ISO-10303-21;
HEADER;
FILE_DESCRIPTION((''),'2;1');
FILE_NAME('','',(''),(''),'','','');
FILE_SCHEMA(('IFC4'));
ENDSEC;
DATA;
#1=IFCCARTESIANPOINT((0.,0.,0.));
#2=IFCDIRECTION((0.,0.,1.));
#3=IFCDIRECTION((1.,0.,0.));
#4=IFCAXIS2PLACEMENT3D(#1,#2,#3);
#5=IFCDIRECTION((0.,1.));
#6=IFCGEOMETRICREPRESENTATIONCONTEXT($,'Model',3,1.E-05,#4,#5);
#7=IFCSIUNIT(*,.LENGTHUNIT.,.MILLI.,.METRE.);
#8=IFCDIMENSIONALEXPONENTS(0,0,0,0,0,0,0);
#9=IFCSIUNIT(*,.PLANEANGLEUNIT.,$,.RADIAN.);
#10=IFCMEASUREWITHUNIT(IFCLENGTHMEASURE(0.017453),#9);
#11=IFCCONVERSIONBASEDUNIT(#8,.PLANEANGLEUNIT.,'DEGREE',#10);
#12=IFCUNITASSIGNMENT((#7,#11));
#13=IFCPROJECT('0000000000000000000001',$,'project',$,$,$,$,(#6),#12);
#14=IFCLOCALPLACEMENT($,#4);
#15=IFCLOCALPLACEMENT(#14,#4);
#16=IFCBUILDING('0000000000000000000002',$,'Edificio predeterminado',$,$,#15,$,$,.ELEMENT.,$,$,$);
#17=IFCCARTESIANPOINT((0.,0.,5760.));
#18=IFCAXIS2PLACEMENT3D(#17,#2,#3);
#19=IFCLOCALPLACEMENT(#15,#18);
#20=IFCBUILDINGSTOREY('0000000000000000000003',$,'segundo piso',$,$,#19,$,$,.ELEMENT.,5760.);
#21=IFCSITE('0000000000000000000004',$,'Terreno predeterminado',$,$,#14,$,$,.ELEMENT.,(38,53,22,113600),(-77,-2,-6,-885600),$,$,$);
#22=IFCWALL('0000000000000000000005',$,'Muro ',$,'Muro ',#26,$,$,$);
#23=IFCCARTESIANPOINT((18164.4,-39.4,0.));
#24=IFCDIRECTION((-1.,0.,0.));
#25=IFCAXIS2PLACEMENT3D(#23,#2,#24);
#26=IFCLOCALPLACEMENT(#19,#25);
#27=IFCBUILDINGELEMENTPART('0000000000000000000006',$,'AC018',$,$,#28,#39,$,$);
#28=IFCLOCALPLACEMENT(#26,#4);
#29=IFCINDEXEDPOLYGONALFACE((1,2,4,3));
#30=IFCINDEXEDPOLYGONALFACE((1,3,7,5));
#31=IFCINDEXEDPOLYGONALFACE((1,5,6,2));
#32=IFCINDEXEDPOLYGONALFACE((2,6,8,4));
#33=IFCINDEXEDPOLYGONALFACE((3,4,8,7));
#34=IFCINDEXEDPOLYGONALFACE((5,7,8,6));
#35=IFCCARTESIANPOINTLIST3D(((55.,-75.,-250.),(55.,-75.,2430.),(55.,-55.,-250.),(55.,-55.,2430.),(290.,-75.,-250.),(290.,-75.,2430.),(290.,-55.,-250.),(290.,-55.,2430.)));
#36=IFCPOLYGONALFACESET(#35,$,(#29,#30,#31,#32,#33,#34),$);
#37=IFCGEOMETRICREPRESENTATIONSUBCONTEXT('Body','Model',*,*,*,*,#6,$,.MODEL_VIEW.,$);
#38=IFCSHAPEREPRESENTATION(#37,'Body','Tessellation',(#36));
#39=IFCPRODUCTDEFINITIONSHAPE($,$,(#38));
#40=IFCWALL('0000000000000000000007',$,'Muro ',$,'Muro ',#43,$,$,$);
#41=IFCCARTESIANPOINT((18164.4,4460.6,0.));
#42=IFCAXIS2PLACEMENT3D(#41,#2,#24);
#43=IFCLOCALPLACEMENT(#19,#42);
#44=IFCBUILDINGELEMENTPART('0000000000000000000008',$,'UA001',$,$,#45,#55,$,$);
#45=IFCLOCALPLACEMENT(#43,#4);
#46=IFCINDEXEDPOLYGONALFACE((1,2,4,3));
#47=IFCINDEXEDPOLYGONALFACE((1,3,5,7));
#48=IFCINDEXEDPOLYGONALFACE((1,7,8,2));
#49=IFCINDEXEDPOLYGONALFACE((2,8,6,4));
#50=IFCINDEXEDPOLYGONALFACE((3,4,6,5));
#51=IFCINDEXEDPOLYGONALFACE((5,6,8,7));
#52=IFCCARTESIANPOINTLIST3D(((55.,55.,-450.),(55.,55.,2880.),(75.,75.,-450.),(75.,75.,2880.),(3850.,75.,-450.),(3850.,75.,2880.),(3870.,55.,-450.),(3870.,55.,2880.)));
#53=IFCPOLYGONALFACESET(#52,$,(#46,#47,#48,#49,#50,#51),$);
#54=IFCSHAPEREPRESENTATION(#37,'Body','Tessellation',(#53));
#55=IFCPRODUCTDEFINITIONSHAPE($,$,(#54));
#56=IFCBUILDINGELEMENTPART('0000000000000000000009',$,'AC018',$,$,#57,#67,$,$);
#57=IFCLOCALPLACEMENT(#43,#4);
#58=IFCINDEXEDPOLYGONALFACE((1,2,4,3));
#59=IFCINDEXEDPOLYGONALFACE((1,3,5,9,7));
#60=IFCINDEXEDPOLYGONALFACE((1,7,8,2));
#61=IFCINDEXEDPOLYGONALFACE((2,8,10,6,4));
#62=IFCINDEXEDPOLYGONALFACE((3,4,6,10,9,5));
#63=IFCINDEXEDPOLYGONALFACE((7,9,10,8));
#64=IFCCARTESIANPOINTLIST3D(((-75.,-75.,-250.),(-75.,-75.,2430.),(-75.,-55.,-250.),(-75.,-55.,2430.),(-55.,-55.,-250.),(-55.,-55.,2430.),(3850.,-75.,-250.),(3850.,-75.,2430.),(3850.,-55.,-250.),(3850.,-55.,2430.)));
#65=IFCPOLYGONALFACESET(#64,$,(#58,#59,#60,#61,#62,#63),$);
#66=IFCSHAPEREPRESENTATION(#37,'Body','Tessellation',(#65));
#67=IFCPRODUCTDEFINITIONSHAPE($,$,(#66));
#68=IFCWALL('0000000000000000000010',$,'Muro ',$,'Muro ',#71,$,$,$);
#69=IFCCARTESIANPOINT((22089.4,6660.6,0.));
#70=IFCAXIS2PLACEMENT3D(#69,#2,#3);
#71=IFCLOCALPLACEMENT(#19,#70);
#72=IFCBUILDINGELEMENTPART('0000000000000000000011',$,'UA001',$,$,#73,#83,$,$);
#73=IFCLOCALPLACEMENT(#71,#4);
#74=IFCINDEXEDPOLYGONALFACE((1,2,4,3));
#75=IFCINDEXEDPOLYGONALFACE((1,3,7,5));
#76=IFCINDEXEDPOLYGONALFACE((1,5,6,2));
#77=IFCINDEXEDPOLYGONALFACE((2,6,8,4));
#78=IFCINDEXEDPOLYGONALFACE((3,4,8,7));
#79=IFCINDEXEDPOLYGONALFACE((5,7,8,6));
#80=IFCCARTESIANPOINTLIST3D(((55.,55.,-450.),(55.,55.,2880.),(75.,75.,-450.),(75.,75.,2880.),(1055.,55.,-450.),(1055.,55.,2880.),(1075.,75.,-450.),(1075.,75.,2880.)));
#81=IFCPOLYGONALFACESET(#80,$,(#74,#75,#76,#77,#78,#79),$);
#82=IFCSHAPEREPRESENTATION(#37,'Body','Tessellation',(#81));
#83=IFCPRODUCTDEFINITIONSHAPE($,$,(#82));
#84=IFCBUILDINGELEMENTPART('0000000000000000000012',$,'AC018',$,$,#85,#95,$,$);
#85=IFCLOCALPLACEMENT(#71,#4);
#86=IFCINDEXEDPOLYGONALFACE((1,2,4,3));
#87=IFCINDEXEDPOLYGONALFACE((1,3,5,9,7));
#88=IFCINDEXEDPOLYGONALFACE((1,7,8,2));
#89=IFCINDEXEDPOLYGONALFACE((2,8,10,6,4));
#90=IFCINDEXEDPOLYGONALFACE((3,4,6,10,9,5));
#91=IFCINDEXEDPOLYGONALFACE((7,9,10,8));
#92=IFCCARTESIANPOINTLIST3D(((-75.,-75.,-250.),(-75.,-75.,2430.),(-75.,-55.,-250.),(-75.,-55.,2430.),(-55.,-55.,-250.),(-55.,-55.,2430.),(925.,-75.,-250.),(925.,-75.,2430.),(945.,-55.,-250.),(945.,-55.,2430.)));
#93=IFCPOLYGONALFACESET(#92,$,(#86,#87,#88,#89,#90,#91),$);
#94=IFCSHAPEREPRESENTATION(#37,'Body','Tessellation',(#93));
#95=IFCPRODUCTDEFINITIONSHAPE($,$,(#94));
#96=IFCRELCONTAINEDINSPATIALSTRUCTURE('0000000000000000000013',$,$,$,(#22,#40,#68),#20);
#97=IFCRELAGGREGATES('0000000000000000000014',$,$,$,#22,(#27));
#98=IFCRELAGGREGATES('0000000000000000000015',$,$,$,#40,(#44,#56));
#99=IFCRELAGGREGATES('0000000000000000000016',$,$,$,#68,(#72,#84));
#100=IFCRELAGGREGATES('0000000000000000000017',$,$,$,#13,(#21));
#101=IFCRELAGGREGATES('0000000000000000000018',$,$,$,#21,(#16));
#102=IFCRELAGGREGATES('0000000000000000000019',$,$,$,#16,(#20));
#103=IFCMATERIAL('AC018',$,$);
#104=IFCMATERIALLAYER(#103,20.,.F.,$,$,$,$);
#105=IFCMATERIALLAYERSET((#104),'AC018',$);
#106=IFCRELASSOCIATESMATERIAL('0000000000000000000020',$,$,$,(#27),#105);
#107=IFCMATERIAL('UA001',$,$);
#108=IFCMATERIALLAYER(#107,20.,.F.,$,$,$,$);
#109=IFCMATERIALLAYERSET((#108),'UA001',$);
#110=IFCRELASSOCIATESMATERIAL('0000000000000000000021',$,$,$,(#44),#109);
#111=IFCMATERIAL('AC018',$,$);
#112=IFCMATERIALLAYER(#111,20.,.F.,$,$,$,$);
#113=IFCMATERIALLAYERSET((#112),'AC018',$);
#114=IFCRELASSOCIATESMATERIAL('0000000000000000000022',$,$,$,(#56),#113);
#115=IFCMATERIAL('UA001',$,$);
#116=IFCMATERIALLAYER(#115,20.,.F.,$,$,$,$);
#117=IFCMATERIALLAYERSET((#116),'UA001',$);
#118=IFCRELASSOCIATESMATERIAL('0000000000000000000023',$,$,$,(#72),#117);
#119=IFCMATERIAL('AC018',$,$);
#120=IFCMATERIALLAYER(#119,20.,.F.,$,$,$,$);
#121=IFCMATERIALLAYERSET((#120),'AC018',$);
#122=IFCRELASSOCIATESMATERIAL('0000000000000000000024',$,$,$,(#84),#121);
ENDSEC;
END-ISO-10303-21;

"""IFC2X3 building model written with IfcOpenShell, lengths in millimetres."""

from ifc_helpers import new_model, entity, si_unit, converted_unit, direction, frame, origin_with_axes, place, context, subcontext, project, spatial, polyline, outline, extrude, material, layer, layer_set, layer_usage, element, aggregate, save


model = new_model("IFC2X3")

# Units and contexts
model_context = context("Model", 3, precision=1e-05, world=origin_with_axes(), true_north=direction((0.0, 1.0)))
body_context = subcontext(model_context, "Body", "Model", "MODEL_VIEW")
ifc_project = project(units=[si_unit("LENGTHUNIT", "METRE", prefix="MILLI"), converted_unit("PLANEANGLEUNIT", "DEGREE", entity("IfcLengthMeasure", 0.017453), si_unit("PLANEANGLEUNIT", "RADIAN"), dimensions=[0, 0, 0, 0, 0, 0, 0])], contexts=[model_context])

# Site, building, storey
site_placement = place(None, origin_with_axes())
site = spatial("IfcSite", under=ifc_project, at=site_placement, Name="Terreno predeterminado", CompositionType="ELEMENT", RefLatitude=(38, 53, 22, 113600), RefLongitude=(-77, -2, -6, -885600))
building_placement = place(site_placement, origin_with_axes())
building = spatial("IfcBuilding", under=site, at=building_placement, Name="Edificio predeterminado", CompositionType="ELEMENT")
storey_placement = place(building_placement, frame((0.0, 0.0, 5760.0), z_axis=(0.0, 0.0, 1.0), x_axis=(1.0, 0.0, 0.0)))
storey = spatial("IfcBuildingStorey", under=building, at=storey_placement, Name="segundo piso", CompositionType="ELEMENT", Elevation=5760.0)

# Wall, building element part
wall_1_placement = place(storey_placement, frame((18164.4, -39.4, 0.0), z_axis=(0.0, 0.0, 1.0), x_axis=(-1.0, 0.0, 0.0)))
wall_1 = element("IfcWall", 1, at=wall_1_placement, inside=storey, Name="Muro ", ObjectType="Muro ")
ifc_material_1 = material(Name="AC018")
ifc_layer_1 = layer(ifc_material_1, 20.0, ventilated=False)
ifc_layer_set_1 = layer_set([ifc_layer_1], Name="AC018")
ifc_layer_usage_1 = layer_usage(ifc_layer_set_1, "AXIS2", "NEGATIVE", 55.0)
building_element_part_1_placement = place(wall_1_placement, origin_with_axes())
building_element_part_1 = element("IfcBuildingElementPart", 2, at=building_element_part_1_placement, material=ifc_layer_usage_1, Name="AC018", context=body_context, shape_type="SweptSolid", body=[
    extrude(outline(polyline([(290.0, -55.0), (290.0, -75.0), (55.0, -75.0), (55.0, -55.0), (290.0, -55.0)])), frame((0.0, 0.0, -250.0), z_axis=(0.0, 0.0, 1.0), x_axis=(1.0, 0.0, 0.0)), (0.0, 0.0, 1.0), 2680.0),
])
aggregate(wall_1, [building_element_part_1])

# Walls, building element parts
wall_2_placement = place(storey_placement, frame((18164.4, 4460.6, 0.0), z_axis=(0.0, 0.0, 1.0), x_axis=(-1.0, 0.0, 0.0)))
wall_2 = element("IfcWall", 3, at=wall_2_placement, inside=storey, Name="Muro ", ObjectType="Muro ")
ifc_material_2 = material(Name="UA001")
ifc_layer_2 = layer(ifc_material_2, 20.0, ventilated=False)
ifc_layer_set_2 = layer_set([ifc_layer_2], Name="UA001")
ifc_layer_usage_2 = layer_usage(ifc_layer_set_2, "AXIS2", "NEGATIVE", -75.0)
building_element_part_2_placement = place(wall_2_placement, origin_with_axes())
building_element_part_2 = element("IfcBuildingElementPart", 4, at=building_element_part_2_placement, material=ifc_layer_usage_2, Name="UA001", context=body_context, shape_type="SweptSolid", body=[
    extrude(outline(polyline([(3850.0, 75.0), (3870.0, 55.0), (55.0, 55.0), (75.0, 75.0), (3850.0, 75.0)])), frame((0.0, 0.0, -450.0), z_axis=(0.0, 0.0, 1.0), x_axis=(1.0, 0.0, 0.0)), (0.0, 0.0, 1.0), 3330.0),
])
ifc_material_3 = material(Name="AC018")
ifc_layer_3 = layer(ifc_material_3, 20.0, ventilated=False)
ifc_layer_set_3 = layer_set([ifc_layer_3], Name="AC018")
ifc_layer_usage_3 = layer_usage(ifc_layer_set_3, "AXIS2", "NEGATIVE", 55.0)
building_element_part_3_placement = place(wall_2_placement, origin_with_axes())
building_element_part_3 = element("IfcBuildingElementPart", 5, at=building_element_part_3_placement, material=ifc_layer_usage_3, Name="AC018", context=body_context, shape_type="SweptSolid", body=[
    extrude(outline(polyline([(3850.0, -55.0), (3850.0, -75.0), (-75.0, -75.0), (-75.0, -55.0), (-55.0, -55.0), (3850.0, -55.0)])), frame((0.0, 0.0, -250.0), z_axis=(0.0, 0.0, 1.0), x_axis=(1.0, 0.0, 0.0)), (0.0, 0.0, 1.0), 2680.0),
])
aggregate(wall_2, [building_element_part_2, building_element_part_3])
wall_3_placement = place(storey_placement, frame((22089.4, 6660.6, 0.0), z_axis=(0.0, 0.0, 1.0), x_axis=(1.0, 0.0, 0.0)))
wall_3 = element("IfcWall", 6, at=wall_3_placement, inside=storey, Name="Muro ", ObjectType="Muro ")
ifc_material_4 = material(Name="UA001")
ifc_layer_4 = layer(ifc_material_4, 20.0, ventilated=False)
ifc_layer_set_4 = layer_set([ifc_layer_4], Name="UA001")
ifc_layer_usage_4 = layer_usage(ifc_layer_set_4, "AXIS2", "NEGATIVE", -75.0)
building_element_part_4_placement = place(wall_3_placement, origin_with_axes())
building_element_part_4 = element("IfcBuildingElementPart", 7, at=building_element_part_4_placement, material=ifc_layer_usage_4, Name="UA001", context=body_context, shape_type="SweptSolid", body=[
    extrude(outline(polyline([(1075.0, 75.0), (1055.0, 55.0), (55.0, 55.0), (75.0, 75.0), (1075.0, 75.0)])), frame((0.0, 0.0, -450.0), z_axis=(0.0, 0.0, 1.0), x_axis=(1.0, 0.0, 0.0)), (0.0, 0.0, 1.0), 3330.0),
])
ifc_material_5 = material(Name="AC018")
ifc_layer_5 = layer(ifc_material_5, 20.0, ventilated=False)
ifc_layer_set_5 = layer_set([ifc_layer_5], Name="AC018")
ifc_layer_usage_5 = layer_usage(ifc_layer_set_5, "AXIS2", "NEGATIVE", 55.0)
building_element_part_5_placement = place(wall_3_placement, origin_with_axes())
building_element_part_5 = element("IfcBuildingElementPart", 8, at=building_element_part_5_placement, material=ifc_layer_usage_5, Name="AC018", context=body_context, shape_type="SweptSolid", body=[
    extrude(outline(polyline([(945.0, -55.0), (925.0, -75.0), (-75.0, -75.0), (-75.0, -55.0), (-55.0, -55.0), (945.0, -55.0)])), frame((0.0, 0.0, -250.0), z_axis=(0.0, 0.0, 1.0), x_axis=(1.0, 0.0, 0.0)), (0.0, 0.0, 1.0), 2680.0),
])
aggregate(wall_3, [building_element_part_4, building_element_part_5])

save(model, "model.ifc")
